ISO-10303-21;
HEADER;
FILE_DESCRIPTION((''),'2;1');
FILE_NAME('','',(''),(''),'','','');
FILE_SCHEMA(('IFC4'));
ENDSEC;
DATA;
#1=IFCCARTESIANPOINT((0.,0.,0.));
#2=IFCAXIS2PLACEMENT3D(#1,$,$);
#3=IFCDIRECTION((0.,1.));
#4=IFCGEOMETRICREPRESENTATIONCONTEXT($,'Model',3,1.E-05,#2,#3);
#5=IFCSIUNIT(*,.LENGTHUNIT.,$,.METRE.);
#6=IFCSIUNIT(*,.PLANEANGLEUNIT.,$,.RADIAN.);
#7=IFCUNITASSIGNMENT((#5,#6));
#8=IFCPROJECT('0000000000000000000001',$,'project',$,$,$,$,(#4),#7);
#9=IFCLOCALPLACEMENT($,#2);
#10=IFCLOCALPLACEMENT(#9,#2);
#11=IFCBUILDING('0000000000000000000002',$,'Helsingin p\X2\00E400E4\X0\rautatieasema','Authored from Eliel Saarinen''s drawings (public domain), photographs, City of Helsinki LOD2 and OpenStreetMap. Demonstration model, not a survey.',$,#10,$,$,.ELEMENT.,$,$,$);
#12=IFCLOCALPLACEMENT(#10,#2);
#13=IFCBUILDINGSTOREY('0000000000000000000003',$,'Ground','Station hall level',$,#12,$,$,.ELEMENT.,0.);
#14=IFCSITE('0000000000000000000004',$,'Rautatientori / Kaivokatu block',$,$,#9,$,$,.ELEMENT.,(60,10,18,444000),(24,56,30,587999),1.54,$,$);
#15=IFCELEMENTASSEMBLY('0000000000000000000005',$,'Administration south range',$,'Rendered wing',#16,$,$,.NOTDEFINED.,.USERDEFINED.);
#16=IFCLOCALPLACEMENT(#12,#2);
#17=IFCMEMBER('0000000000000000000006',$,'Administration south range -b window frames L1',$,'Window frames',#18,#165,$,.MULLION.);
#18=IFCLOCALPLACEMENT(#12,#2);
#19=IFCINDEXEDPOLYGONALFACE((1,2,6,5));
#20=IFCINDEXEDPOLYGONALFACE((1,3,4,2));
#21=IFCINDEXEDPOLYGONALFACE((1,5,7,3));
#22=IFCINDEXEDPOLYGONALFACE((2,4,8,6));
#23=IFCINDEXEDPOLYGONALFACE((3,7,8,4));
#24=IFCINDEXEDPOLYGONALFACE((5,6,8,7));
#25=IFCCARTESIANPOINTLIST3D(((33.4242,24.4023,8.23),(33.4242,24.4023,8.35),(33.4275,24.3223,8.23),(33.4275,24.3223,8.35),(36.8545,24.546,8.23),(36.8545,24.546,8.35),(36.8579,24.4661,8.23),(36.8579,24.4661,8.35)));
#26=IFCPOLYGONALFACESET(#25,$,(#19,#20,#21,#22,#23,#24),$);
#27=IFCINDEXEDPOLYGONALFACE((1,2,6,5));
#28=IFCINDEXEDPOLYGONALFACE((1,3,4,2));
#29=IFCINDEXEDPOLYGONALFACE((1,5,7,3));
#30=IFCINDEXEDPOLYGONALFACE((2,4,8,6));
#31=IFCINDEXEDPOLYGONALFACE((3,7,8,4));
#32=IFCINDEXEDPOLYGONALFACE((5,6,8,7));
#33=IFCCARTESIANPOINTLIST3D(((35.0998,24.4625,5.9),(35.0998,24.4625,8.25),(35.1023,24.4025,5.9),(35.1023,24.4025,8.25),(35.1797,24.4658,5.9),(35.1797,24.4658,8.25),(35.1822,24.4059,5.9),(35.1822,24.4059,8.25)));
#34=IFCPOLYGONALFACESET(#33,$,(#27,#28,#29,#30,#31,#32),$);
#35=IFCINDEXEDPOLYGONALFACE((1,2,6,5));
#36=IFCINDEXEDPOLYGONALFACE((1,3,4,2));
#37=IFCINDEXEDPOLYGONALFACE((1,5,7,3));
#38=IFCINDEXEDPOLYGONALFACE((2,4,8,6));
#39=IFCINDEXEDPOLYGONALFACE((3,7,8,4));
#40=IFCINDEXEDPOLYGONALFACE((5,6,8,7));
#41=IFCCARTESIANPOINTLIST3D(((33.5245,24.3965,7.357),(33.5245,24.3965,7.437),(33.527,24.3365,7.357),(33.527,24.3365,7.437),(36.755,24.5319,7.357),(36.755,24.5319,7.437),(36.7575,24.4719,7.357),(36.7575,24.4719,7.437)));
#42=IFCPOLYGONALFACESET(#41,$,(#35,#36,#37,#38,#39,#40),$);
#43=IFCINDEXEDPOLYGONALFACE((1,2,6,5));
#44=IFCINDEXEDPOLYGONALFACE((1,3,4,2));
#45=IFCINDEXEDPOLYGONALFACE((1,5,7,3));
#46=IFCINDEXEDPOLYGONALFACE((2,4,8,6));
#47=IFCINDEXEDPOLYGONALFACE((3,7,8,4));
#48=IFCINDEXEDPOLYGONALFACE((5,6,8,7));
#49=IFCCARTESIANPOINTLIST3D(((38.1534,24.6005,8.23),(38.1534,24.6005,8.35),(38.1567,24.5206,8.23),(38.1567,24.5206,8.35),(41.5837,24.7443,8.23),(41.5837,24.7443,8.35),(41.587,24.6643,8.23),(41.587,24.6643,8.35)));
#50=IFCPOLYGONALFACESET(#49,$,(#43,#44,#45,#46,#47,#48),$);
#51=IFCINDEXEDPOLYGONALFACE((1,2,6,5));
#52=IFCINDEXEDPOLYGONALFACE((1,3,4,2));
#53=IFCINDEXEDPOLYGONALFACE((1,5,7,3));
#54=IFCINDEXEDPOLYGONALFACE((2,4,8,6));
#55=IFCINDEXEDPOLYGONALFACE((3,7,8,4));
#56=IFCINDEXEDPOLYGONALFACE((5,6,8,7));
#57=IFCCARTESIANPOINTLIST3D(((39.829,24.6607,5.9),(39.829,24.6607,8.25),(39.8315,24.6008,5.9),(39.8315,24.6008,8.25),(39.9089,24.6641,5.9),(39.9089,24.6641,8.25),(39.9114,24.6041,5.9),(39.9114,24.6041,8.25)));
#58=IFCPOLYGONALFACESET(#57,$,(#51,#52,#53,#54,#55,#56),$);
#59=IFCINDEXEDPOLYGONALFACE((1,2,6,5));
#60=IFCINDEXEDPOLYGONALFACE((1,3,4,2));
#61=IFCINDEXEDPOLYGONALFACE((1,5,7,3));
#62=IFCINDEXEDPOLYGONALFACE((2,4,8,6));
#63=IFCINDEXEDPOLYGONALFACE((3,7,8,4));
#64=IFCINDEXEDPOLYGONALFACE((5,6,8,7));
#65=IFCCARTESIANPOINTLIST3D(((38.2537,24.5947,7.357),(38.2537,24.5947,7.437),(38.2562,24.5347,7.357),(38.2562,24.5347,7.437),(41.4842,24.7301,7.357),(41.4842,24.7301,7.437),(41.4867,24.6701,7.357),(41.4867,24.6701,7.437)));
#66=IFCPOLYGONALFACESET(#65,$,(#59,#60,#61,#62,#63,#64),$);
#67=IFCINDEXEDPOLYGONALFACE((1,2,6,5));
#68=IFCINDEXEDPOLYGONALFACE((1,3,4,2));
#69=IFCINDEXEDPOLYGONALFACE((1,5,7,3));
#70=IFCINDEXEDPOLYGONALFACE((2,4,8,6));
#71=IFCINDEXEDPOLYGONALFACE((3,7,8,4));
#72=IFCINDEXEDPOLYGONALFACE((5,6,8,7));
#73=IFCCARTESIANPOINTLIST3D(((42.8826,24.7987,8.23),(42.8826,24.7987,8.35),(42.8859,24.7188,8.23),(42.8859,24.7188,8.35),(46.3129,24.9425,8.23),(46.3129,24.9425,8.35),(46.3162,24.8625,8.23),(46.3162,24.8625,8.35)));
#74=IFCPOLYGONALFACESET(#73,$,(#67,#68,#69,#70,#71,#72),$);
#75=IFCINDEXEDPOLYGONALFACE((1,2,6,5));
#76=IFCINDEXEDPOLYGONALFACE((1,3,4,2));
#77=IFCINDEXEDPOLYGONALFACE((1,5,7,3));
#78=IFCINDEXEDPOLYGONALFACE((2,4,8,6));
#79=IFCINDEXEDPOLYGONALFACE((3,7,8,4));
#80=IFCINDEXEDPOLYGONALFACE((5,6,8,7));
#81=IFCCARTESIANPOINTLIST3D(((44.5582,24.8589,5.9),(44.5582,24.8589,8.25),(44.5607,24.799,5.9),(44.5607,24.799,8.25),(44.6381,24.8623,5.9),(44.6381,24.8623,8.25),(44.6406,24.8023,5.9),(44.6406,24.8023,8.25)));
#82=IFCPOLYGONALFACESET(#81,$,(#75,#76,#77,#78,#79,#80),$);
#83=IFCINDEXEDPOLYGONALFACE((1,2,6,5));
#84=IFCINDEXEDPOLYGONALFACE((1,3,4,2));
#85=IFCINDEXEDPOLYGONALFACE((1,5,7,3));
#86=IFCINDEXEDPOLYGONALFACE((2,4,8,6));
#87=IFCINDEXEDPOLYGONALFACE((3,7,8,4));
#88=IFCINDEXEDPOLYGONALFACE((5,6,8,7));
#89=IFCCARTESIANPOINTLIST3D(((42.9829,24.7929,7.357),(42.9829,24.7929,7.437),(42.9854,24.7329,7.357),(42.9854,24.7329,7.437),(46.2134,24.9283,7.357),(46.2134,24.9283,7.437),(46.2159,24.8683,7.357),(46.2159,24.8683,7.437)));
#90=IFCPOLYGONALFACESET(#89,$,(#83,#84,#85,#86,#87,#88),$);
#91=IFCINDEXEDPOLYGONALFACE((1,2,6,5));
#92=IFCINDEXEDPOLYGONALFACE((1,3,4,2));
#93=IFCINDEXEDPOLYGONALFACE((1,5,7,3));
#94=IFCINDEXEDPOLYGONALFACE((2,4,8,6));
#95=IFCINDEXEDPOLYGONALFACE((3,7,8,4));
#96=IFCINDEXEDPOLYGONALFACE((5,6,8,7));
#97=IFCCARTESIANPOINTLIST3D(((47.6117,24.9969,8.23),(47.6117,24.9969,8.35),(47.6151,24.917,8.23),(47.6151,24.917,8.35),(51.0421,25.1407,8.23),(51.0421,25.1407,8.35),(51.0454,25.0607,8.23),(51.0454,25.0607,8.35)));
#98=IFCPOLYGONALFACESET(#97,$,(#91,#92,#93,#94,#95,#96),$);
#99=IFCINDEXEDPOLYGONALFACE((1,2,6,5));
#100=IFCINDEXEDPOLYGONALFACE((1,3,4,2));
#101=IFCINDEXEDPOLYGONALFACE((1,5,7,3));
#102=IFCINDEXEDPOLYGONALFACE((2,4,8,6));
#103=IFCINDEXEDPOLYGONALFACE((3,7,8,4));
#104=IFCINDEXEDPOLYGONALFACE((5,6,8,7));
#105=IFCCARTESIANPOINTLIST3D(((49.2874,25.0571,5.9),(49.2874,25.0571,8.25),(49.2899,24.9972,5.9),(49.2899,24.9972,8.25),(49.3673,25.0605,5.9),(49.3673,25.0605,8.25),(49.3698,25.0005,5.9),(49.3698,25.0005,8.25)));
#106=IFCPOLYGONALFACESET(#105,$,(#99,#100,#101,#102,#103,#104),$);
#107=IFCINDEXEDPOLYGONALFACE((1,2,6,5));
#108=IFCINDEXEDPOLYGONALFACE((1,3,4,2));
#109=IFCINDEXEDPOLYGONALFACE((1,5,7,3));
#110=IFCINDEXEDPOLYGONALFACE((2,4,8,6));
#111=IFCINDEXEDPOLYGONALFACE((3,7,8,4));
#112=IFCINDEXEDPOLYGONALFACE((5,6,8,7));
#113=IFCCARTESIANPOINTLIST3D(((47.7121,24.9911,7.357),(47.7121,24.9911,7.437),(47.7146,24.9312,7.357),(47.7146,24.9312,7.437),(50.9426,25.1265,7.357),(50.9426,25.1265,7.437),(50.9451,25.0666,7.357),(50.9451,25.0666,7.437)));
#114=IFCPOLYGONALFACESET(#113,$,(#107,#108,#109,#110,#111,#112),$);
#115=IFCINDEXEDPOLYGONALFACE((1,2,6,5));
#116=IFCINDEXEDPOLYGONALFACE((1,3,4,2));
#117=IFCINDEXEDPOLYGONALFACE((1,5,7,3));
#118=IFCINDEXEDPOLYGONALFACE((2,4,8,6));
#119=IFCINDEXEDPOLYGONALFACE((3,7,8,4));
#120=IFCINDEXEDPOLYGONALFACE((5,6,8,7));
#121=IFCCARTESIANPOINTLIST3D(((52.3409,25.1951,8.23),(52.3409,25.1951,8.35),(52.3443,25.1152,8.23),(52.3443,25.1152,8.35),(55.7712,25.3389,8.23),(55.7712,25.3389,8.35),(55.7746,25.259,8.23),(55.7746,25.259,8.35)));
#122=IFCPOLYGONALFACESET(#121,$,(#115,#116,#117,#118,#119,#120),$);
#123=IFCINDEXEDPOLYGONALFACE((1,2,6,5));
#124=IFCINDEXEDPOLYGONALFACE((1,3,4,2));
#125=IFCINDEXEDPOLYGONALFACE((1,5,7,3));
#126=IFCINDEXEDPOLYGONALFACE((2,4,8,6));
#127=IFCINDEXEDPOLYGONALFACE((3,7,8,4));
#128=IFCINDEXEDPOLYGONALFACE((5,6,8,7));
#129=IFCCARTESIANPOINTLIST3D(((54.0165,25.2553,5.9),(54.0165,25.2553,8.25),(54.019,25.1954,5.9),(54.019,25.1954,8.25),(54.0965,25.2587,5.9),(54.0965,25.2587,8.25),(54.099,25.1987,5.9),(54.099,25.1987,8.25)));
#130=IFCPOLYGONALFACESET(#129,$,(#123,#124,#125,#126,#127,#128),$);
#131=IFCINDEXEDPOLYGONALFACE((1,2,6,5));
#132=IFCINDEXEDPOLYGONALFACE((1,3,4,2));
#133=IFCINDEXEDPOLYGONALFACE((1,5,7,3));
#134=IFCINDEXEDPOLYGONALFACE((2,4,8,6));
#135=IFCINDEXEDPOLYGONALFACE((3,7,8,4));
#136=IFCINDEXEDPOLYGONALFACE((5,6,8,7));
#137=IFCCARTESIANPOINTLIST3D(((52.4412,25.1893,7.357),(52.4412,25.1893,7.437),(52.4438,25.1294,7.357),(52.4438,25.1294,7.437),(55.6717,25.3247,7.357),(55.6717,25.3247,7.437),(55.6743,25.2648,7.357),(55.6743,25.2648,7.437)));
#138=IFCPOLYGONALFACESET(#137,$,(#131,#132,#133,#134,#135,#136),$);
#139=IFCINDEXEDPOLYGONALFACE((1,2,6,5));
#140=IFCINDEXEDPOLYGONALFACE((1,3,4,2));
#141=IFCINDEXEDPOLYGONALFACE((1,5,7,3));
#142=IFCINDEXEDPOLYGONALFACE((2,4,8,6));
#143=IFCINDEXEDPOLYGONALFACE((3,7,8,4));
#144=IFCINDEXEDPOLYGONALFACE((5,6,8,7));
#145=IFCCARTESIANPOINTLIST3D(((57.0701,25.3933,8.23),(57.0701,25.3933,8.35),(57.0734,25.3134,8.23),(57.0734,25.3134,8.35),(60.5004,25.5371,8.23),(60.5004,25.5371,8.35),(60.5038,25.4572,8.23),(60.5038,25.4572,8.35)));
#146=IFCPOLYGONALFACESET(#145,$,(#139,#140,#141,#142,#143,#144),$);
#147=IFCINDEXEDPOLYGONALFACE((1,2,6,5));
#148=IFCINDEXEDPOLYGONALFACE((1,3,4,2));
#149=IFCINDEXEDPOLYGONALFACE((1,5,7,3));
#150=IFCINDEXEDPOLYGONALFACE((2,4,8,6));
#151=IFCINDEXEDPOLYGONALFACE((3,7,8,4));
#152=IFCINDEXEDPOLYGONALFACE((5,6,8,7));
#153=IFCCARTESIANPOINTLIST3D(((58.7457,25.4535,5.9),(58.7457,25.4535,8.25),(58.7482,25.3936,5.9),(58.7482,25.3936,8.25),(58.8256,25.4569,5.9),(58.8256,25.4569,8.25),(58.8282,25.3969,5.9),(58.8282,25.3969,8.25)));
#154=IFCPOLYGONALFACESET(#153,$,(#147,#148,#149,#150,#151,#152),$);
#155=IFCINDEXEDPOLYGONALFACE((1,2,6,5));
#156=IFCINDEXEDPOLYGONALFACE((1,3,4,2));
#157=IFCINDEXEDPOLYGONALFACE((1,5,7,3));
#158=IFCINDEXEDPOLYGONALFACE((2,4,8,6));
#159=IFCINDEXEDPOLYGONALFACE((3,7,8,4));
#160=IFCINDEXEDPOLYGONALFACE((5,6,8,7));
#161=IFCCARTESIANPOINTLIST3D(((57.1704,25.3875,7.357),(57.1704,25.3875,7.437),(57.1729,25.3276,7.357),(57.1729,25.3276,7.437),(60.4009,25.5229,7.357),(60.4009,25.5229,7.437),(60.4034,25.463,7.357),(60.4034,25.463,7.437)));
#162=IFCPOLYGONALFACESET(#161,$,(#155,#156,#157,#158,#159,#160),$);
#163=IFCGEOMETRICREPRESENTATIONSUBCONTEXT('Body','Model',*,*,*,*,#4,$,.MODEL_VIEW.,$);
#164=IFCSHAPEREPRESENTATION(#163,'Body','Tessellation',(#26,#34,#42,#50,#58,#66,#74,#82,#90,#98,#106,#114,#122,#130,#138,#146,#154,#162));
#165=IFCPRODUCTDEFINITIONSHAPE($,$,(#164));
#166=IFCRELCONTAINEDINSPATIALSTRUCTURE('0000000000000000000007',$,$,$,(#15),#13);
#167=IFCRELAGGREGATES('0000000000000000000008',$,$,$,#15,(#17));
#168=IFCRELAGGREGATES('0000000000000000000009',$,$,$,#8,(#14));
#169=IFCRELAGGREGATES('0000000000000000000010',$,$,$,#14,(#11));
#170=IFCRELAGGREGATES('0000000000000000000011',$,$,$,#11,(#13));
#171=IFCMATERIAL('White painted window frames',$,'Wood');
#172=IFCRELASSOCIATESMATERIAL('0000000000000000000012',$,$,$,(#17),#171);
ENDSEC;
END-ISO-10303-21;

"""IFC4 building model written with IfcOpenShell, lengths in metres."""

from ifc_helpers import new_model, si_unit, direction, frame, frame_2d, origin, place, context, subcontext, project, spatial, rectangle, extrude, material, element, aggregate, save


model = new_model("IFC4")

# Units and contexts
model_context = context("Model", 3, precision=1e-05, world=origin(), true_north=direction((0.0, 1.0)))
body_context = subcontext(model_context, "Body", "Model", "MODEL_VIEW")
ifc_project = project(units=[si_unit("LENGTHUNIT", "METRE"), si_unit("PLANEANGLEUNIT", "RADIAN")], contexts=[model_context])

# Site, building, storey
site_placement = place(None, origin())
site = spatial("IfcSite", under=ifc_project, at=site_placement, Name="Rautatientori / Kaivokatu block", CompositionType="ELEMENT", RefLatitude=(60, 10, 18, 444000), RefLongitude=(24, 56, 30, 587999), RefElevation=1.54)
building_placement = place(site_placement, origin())
building = spatial("IfcBuilding", under=site, at=building_placement, Name="Helsingin päärautatieasema", Description="Authored from Eliel Saarinen's drawings (public domain), photographs, City of Helsinki LOD2 and OpenStreetMap. Demonstration model, not a survey.", CompositionType="ELEMENT")
storey_placement = place(building_placement, origin())
storey = spatial("IfcBuildingStorey", under=building, at=storey_placement, Name="Ground", Description="Station hall level", CompositionType="ELEMENT", Elevation=0.0)

# Element assembly, member
assembly_1_placement = place(building_placement, origin())
assembly_1 = element("IfcElementAssembly", 1, at=assembly_1_placement, inside=storey, Name="Administration south range", ObjectType="Rendered wing", AssemblyPlace="NOTDEFINED", PredefinedType="USERDEFINED")
ifc_material_1 = material(Name="White painted window frames", Category="Wood")
member_1_placement = place(building_placement, origin())
member_1 = element("IfcMember", 2, at=member_1_placement, material=ifc_material_1, Name="Administration south range -b window frames L1", ObjectType="Window frames", PredefinedType="MULLION", context=body_context, shape_type="SweptSolid", body=[
    extrude(rectangle(XDim=3.4333, YDim=0.08, at=frame_2d((0.0, 0.0), x_axis=(0.999123, 0.041876))), frame((35.141, 24.4342, 8.23)), (0.0, 0.0, 1.0), 0.12),
    extrude(rectangle(XDim=0.08, YDim=0.06, at=frame_2d((0.0, 0.0), x_axis=(0.999123, 0.041876))), frame((35.141, 24.4342, 5.9)), (0.0, 0.0, 1.0), 2.35),
    extrude(rectangle(XDim=3.2333, YDim=0.06, at=frame_2d((0.0, 0.0), x_axis=(0.999123, 0.041876))), frame((35.141, 24.4342, 7.357)), (0.0, 0.0, 1.0), 0.08),
    extrude(rectangle(XDim=3.4333, YDim=0.08, at=frame_2d((0.0, 0.0), x_axis=(0.999123, 0.041876))), frame((39.8702, 24.6324, 8.23)), (0.0, 0.0, 1.0), 0.12),
    extrude(rectangle(XDim=0.08, YDim=0.06, at=frame_2d((0.0, 0.0), x_axis=(0.999123, 0.041876))), frame((39.8702, 24.6324, 5.9)), (0.0, 0.0, 1.0), 2.35),
    extrude(rectangle(XDim=3.2333, YDim=0.06, at=frame_2d((0.0, 0.0), x_axis=(0.999123, 0.041876))), frame((39.8702, 24.6324, 7.357)), (0.0, 0.0, 1.0), 0.08),
    extrude(rectangle(XDim=3.4333, YDim=0.08, at=frame_2d((0.0, 0.0), x_axis=(0.999123, 0.041876))), frame((44.5994, 24.8306, 8.23)), (0.0, 0.0, 1.0), 0.12),
    extrude(rectangle(XDim=0.08, YDim=0.06, at=frame_2d((0.0, 0.0), x_axis=(0.999123, 0.041876))), frame((44.5994, 24.8306, 5.9)), (0.0, 0.0, 1.0), 2.35),
    extrude(rectangle(XDim=3.2333, YDim=0.06, at=frame_2d((0.0, 0.0), x_axis=(0.999123, 0.041876))), frame((44.5994, 24.8306, 7.357)), (0.0, 0.0, 1.0), 0.08),
    extrude(rectangle(XDim=3.4333, YDim=0.08, at=frame_2d((0.0, 0.0), x_axis=(0.999123, 0.041876))), frame((49.3286, 25.0288, 8.23)), (0.0, 0.0, 1.0), 0.12),
    extrude(rectangle(XDim=0.08, YDim=0.06, at=frame_2d((0.0, 0.0), x_axis=(0.999123, 0.041876))), frame((49.3286, 25.0288, 5.9)), (0.0, 0.0, 1.0), 2.35),
    extrude(rectangle(XDim=3.2333, YDim=0.06, at=frame_2d((0.0, 0.0), x_axis=(0.999123, 0.041876))), frame((49.3286, 25.0288, 7.357)), (0.0, 0.0, 1.0), 0.08),
    extrude(rectangle(XDim=3.4333, YDim=0.08, at=frame_2d((0.0, 0.0), x_axis=(0.999123, 0.041876))), frame((54.0578, 25.227, 8.23)), (0.0, 0.0, 1.0), 0.12),
    extrude(rectangle(XDim=0.08, YDim=0.06, at=frame_2d((0.0, 0.0), x_axis=(0.999123, 0.041876))), frame((54.0578, 25.227, 5.9)), (0.0, 0.0, 1.0), 2.35),
    extrude(rectangle(XDim=3.2333, YDim=0.06, at=frame_2d((0.0, 0.0), x_axis=(0.999123, 0.041876))), frame((54.0578, 25.227, 7.357)), (0.0, 0.0, 1.0), 0.08),
    extrude(rectangle(XDim=3.4333, YDim=0.08, at=frame_2d((0.0, 0.0), x_axis=(0.999123, 0.041876))), frame((58.7869, 25.4252, 8.23)), (0.0, 0.0, 1.0), 0.12),
    extrude(rectangle(XDim=0.08, YDim=0.06, at=frame_2d((0.0, 0.0), x_axis=(0.999123, 0.041876))), frame((58.7869, 25.4252, 5.9)), (0.0, 0.0, 1.0), 2.35),
    extrude(rectangle(XDim=3.2333, YDim=0.06, at=frame_2d((0.0, 0.0), x_axis=(0.999123, 0.041876))), frame((58.7869, 25.4252, 7.357)), (0.0, 0.0, 1.0), 0.08),
])

aggregate(assembly_1, [member_1])

save(model, "model.ifc")
